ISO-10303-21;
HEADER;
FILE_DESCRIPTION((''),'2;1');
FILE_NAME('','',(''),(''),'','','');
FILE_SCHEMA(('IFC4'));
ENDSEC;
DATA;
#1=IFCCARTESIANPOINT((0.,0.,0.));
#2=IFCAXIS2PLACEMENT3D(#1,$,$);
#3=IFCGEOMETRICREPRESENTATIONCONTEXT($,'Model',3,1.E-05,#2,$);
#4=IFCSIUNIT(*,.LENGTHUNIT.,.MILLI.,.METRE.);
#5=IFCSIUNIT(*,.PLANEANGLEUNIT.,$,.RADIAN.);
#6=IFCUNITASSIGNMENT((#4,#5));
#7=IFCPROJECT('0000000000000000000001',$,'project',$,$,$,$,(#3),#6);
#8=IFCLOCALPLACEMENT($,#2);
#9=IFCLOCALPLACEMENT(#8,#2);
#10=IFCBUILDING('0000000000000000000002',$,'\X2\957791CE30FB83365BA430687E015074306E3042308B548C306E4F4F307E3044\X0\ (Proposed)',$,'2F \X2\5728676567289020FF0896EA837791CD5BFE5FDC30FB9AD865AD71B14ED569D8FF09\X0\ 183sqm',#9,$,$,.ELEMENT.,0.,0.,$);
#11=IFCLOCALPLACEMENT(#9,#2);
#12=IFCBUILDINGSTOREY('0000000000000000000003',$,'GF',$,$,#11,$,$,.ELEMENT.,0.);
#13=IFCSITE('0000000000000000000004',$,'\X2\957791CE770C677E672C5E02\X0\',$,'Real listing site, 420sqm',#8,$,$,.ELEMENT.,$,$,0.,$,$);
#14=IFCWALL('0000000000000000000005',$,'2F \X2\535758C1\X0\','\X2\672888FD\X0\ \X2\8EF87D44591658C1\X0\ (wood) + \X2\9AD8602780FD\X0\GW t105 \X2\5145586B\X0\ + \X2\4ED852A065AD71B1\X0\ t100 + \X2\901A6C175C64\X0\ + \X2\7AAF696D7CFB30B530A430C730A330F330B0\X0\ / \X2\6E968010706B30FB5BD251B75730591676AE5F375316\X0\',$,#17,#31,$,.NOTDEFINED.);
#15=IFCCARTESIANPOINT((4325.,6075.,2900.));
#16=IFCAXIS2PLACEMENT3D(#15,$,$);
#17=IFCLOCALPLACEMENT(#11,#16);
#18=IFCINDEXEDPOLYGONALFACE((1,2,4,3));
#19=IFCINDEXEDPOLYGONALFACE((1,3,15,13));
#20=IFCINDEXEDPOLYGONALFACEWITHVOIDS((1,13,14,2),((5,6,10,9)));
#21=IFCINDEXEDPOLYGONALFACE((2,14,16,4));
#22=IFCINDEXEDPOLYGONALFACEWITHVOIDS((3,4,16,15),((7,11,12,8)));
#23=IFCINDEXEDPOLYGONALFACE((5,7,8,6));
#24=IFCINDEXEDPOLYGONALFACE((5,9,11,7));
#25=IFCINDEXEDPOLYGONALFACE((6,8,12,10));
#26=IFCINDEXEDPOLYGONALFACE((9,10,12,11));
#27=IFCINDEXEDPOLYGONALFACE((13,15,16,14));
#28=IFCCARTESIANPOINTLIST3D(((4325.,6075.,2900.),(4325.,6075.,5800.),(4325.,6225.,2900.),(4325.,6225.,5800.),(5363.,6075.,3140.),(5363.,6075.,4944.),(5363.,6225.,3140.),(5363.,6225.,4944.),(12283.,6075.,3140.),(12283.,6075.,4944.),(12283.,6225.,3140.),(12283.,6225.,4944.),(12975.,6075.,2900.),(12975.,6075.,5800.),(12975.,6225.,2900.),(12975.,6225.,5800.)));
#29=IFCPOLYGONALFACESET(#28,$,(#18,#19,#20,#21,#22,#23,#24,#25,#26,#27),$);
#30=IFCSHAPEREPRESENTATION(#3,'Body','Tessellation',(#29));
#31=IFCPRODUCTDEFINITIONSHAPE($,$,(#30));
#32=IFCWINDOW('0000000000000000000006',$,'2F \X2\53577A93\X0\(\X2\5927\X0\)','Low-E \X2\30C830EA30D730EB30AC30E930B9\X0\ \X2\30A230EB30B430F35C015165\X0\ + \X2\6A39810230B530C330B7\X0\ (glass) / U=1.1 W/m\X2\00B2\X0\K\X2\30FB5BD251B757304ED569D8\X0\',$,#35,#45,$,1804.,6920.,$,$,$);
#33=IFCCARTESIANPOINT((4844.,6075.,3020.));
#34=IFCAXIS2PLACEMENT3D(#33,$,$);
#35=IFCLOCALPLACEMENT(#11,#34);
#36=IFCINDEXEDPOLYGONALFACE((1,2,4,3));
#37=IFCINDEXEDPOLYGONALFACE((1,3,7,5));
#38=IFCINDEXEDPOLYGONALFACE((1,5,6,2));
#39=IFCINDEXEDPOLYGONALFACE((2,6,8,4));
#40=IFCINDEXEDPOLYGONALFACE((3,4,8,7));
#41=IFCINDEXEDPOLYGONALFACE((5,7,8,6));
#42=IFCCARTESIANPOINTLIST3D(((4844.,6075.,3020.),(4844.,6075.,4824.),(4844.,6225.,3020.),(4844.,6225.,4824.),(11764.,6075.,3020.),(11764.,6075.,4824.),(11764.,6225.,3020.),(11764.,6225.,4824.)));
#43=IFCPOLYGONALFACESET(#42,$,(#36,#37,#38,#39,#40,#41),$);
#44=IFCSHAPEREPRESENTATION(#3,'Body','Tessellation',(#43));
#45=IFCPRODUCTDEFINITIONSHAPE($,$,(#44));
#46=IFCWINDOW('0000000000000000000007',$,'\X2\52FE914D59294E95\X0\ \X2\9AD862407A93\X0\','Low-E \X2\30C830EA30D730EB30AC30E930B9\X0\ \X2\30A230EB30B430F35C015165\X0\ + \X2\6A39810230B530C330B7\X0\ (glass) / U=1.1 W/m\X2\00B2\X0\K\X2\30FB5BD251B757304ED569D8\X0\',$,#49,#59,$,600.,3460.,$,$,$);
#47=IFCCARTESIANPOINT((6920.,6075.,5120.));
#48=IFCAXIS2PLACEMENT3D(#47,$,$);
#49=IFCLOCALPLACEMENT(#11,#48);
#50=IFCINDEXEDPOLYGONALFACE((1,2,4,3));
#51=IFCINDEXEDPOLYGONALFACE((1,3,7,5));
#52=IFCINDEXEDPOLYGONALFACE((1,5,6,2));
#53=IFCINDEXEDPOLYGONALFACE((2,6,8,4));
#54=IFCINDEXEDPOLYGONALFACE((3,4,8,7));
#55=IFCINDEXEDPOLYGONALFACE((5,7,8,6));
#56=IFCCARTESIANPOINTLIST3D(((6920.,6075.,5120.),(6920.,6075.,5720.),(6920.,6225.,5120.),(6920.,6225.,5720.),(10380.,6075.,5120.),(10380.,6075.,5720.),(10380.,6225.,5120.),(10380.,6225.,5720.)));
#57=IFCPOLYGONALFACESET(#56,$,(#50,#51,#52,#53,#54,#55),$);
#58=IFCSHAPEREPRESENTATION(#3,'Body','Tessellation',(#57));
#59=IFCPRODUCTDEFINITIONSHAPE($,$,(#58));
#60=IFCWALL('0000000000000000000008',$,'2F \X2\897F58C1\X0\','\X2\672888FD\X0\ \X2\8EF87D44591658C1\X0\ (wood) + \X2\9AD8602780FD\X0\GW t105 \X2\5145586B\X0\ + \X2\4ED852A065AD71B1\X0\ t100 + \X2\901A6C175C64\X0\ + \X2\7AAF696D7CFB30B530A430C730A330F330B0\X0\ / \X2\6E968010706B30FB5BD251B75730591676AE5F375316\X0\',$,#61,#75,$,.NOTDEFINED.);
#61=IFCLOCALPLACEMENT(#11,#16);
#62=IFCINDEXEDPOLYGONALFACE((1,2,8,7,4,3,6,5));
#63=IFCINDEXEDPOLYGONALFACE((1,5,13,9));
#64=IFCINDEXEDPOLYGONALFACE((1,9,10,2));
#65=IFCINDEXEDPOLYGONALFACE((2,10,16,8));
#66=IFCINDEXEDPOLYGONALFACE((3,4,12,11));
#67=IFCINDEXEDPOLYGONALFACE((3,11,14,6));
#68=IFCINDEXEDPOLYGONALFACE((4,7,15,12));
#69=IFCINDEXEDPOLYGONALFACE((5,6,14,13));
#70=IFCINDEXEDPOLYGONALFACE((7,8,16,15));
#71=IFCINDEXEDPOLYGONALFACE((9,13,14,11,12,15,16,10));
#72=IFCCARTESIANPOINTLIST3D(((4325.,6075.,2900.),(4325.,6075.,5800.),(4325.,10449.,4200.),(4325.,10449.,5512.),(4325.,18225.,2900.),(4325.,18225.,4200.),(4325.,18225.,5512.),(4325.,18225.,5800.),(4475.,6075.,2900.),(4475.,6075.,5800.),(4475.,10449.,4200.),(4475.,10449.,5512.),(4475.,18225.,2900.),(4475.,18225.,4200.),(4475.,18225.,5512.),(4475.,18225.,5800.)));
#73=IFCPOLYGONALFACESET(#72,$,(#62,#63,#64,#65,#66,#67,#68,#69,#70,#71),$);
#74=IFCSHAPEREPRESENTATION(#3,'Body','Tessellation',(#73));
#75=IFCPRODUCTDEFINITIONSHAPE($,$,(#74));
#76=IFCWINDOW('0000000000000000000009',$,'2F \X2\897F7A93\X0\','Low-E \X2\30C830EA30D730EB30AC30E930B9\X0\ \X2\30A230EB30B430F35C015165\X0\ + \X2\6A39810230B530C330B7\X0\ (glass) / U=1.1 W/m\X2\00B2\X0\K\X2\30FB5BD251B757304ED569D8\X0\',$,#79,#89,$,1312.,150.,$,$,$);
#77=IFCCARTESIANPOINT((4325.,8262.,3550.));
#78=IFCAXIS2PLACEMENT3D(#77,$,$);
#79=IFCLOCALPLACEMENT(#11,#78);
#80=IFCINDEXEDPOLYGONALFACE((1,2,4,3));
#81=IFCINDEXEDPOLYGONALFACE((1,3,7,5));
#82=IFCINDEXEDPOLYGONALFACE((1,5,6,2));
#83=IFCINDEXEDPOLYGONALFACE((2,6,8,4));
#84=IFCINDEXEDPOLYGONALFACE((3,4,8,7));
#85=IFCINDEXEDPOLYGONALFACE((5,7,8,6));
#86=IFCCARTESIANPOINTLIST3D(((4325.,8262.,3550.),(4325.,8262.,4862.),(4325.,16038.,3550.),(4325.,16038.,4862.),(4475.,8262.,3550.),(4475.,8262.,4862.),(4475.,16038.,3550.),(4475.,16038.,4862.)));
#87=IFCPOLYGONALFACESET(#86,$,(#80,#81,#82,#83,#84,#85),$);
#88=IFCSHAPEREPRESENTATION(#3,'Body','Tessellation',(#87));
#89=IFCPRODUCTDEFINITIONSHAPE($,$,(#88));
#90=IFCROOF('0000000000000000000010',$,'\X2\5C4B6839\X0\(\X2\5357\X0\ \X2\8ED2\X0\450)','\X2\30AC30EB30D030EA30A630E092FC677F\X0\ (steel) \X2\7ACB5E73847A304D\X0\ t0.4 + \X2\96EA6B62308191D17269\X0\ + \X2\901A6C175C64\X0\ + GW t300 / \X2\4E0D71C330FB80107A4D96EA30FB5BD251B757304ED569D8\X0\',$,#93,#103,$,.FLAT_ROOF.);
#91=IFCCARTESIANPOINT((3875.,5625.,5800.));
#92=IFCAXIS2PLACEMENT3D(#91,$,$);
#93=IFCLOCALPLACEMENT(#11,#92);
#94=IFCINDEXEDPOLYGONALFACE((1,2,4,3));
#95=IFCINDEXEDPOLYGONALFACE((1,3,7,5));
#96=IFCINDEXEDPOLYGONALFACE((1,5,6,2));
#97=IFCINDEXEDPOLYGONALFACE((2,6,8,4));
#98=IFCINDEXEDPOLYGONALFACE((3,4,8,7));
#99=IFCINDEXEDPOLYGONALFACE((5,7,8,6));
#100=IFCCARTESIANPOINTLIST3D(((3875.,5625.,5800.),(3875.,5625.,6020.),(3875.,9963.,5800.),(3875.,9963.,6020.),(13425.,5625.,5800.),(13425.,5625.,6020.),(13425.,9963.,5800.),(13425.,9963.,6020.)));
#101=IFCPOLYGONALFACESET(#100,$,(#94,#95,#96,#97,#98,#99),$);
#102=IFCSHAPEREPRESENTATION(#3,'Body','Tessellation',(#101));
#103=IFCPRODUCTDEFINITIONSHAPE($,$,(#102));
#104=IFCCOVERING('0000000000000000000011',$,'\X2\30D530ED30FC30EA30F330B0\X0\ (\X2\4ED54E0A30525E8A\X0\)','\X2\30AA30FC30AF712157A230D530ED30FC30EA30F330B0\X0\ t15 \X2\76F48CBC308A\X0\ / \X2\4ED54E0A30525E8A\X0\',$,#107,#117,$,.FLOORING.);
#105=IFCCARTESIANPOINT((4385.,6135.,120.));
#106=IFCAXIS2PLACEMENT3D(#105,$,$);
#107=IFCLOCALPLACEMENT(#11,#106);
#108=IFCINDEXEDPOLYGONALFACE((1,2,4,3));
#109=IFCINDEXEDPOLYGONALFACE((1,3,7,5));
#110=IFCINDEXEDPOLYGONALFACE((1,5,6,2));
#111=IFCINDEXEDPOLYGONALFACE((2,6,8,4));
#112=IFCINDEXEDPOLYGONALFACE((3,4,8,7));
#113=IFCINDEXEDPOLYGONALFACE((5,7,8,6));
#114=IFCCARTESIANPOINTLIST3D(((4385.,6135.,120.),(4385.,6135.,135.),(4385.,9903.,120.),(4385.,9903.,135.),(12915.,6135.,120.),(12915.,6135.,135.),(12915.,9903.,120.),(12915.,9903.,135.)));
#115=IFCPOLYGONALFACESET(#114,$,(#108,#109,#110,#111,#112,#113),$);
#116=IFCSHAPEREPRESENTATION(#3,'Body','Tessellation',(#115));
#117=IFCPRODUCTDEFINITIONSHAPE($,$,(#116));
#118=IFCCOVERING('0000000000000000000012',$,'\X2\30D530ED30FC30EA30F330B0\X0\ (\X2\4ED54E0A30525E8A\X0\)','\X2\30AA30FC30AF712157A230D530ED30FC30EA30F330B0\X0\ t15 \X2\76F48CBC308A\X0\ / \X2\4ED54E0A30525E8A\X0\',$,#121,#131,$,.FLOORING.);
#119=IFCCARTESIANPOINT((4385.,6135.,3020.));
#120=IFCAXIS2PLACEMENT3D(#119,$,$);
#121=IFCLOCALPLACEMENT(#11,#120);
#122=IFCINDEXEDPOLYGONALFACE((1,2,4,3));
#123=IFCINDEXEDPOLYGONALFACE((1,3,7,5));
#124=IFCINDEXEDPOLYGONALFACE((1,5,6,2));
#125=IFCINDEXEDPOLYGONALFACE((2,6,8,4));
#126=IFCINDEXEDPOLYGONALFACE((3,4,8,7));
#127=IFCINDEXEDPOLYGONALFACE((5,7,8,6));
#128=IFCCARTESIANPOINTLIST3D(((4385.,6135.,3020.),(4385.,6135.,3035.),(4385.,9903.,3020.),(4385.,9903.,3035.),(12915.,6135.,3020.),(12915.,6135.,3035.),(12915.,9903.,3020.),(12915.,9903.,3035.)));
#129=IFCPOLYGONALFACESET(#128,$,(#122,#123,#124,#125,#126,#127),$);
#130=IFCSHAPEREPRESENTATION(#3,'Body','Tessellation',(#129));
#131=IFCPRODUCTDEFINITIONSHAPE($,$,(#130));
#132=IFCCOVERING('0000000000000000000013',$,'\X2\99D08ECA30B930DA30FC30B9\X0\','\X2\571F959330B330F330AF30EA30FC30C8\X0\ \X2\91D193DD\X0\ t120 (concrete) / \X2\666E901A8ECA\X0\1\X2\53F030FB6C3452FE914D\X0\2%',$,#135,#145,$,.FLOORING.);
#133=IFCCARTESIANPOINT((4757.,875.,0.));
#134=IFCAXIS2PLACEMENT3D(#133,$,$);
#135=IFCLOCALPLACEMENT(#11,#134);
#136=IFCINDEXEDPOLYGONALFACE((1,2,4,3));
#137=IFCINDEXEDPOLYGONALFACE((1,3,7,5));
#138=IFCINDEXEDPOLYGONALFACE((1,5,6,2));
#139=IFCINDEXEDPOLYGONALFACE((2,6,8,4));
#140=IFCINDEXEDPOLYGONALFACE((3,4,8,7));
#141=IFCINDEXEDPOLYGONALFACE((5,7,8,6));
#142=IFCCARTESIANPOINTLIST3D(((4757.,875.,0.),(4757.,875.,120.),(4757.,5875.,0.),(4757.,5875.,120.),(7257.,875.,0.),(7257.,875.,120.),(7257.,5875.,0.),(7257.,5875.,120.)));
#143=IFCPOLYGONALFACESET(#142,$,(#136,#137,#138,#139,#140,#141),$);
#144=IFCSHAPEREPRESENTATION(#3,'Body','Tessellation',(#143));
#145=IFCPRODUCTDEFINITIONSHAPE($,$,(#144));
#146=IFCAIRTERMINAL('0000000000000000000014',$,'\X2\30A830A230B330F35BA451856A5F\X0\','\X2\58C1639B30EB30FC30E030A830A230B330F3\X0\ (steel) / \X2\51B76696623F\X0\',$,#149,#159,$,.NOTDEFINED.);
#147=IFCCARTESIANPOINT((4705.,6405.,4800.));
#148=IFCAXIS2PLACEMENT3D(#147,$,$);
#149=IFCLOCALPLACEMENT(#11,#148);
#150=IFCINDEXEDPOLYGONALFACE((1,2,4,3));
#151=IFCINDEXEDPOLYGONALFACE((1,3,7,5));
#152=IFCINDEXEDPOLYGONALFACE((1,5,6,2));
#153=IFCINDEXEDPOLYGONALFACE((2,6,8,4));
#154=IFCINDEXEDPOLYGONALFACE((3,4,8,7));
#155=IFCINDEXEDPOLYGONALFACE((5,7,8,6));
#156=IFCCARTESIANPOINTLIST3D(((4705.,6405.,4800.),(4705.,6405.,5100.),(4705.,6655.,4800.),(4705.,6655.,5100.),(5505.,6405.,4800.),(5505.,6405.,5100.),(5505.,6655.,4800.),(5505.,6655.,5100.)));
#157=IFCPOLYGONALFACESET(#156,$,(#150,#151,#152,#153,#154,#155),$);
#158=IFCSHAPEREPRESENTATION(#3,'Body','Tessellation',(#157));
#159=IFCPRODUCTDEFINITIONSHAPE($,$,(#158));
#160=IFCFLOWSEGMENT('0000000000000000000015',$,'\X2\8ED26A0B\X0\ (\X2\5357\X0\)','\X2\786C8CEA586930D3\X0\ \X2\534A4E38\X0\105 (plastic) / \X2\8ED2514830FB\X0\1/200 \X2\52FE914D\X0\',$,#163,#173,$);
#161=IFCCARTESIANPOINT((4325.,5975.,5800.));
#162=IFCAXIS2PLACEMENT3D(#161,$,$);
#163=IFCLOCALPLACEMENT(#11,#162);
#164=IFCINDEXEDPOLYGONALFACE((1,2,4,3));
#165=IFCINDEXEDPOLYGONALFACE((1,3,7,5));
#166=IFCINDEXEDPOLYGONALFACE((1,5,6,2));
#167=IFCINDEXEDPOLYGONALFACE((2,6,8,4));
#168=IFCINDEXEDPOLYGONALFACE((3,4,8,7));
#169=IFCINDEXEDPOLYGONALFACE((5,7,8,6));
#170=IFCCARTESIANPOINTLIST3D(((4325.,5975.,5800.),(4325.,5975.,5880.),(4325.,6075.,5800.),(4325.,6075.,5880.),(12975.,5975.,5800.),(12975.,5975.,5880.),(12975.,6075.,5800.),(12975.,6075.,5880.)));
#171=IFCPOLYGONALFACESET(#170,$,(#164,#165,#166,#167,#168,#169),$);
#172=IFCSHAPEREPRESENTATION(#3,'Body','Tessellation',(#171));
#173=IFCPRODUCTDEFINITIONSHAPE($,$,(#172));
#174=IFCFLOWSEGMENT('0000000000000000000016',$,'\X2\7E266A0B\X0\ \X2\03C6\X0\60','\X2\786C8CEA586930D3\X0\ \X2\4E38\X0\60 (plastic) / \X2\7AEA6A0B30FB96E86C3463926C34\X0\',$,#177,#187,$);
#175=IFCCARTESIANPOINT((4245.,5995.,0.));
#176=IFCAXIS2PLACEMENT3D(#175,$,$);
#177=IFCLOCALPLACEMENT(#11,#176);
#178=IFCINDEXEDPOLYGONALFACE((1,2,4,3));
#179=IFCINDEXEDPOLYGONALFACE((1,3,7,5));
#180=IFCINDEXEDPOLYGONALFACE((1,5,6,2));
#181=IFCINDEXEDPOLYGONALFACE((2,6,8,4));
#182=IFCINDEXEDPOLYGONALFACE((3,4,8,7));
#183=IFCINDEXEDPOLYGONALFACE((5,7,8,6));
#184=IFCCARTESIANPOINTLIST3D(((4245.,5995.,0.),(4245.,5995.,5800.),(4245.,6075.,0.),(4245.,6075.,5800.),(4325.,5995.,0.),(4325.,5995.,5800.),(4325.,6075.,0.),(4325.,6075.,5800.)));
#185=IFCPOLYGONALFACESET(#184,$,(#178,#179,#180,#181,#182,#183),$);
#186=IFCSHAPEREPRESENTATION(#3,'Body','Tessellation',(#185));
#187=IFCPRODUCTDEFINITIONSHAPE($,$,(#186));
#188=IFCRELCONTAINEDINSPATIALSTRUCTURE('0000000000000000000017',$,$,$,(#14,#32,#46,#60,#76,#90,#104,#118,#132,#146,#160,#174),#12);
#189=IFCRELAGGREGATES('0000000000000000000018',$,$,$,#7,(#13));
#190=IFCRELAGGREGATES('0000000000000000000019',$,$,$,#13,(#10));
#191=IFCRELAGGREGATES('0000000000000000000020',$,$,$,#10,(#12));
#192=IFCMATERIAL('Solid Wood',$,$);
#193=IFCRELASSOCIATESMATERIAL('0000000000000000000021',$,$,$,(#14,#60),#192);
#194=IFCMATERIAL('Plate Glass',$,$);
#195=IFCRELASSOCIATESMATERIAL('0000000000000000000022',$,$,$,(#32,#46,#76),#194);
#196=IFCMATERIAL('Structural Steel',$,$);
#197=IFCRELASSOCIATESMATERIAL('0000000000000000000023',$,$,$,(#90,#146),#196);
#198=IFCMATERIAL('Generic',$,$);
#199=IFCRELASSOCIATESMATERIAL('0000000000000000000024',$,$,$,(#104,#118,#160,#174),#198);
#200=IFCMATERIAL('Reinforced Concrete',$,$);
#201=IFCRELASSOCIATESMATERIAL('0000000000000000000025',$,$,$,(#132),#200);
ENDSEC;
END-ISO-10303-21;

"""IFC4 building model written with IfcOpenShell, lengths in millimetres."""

from ifc_helpers import new_model, si_unit, frame, frame_2d, origin, place, context, project, spatial, rectangle, extrude, material, element, fill, save


model = new_model("IFC4")

# Units and contexts
model_context = context("Model", 3, precision=1e-05, world=origin())
ifc_project = project(units=[si_unit("LENGTHUNIT", "METRE", prefix="MILLI"), si_unit("PLANEANGLEUNIT", "RADIAN")], contexts=[model_context])

# Site, building, storey
site_placement = place(None, origin())
site = spatial("IfcSite", under=ifc_project, at=site_placement, Name="長野県松本市", ObjectType="Real listing site, 420sqm", CompositionType="ELEMENT", RefElevation=0.0)
building_placement = place(site_placement, origin())
building = spatial("IfcBuilding", under=site, at=building_placement, Name="長野・茶室と縁側のある和の住まい (Proposed)", ObjectType="2F 在来木造（雪荷重対応・高断熱仕様） 183sqm", CompositionType="ELEMENT", ElevationOfRefHeight=0.0, ElevationOfTerrain=0.0)
storey_placement = place(building_placement, origin())
storey = spatial("IfcBuildingStorey", under=building, at=storey_placement, Name="GF", CompositionType="ELEMENT", Elevation=0.0)

# Shared definitions
ifc_material_1 = material(Name="Solid Wood")

# Shared definitions
ifc_material_2 = material(Name="Reinforced Concrete")

# Shared definitions
ifc_material_3 = material(Name="Plate Glass")

# Wall, openings, windows
wall_1_placement = place(storey_placement, frame((4325.0, 6075.0, 2900.0)))
wall_1 = element("IfcWall", 1, at=wall_1_placement, inside=storey, material=ifc_material_1, Name="2F 南壁", Description="木製 軸組外壁 (wood) + 高性能GW t105 充填 + 付加断熱 t100 + 通気層 + 窯業系サイディング / 準耐火・寒冷地外皮強化", PredefinedType="NOTDEFINED", context=model_context, shape_type="SweptSolid", body=[
    extrude(rectangle(XDim=8650.0, YDim=150.0, at=frame_2d((4325.0, 75.0))), frame((4325.0, 6075.0, 2900.0)), (0.0, 0.0, 1.0), 2900.0),
])
opening_1_placement = place(storey_placement, frame((4844.0, 6075.0, 3020.0)))
opening_1 = element("IfcOpeningElement", 2, at=opening_1_placement, cuts=wall_1, PredefinedType="NOTDEFINED", context=model_context, shape_type="SweptSolid", body=[
    extrude(rectangle(XDim=6920.0, YDim=150.0, at=frame_2d((3460.0, 75.0))), frame((4844.0, 6075.0, 3020.0)), (0.0, 0.0, 1.0), 1804.0),
])
opening_2_placement = place(storey_placement, frame((6920.0, 6075.0, 5120.0)))
opening_2 = element("IfcOpeningElement", 3, at=opening_2_placement, cuts=wall_1, PredefinedType="NOTDEFINED", context=model_context, shape_type="SweptSolid", body=[
    extrude(rectangle(XDim=3460.0, YDim=150.0, at=frame_2d((1730.0, 75.0))), frame((6920.0, 6075.0, 5120.0)), (0.0, 0.0, 1.0), 600.0),
])
window_1_placement = place(storey_placement, frame((4844.0, 6075.0, 3020.0)))
window_1 = element("IfcWindow", 4, at=window_1_placement, inside=storey, material=ifc_material_3, Name="2F 南窓(大)", Description="Low-E トリプルガラス アルゴン封入 + 樹脂サッシ (glass) / U=1.1 W/m²K・寒冷地仕様", OverallHeight=1804.0, OverallWidth=6920.0, context=model_context, shape_type="SweptSolid", body=[
    extrude(rectangle(XDim=6920.0, YDim=150.0, at=frame_2d((3460.0, 75.0))), frame((4844.0, 6075.0, 3020.0)), (0.0, 0.0, 1.0), 1804.0),
])
fill(opening_1, window_1)
window_2_placement = place(storey_placement, frame((6920.0, 6075.0, 5120.0)))
window_2 = element("IfcWindow", 5, at=window_2_placement, inside=storey, material=ifc_material_3, Name="勾配天井 高所窓", Description="Low-E トリプルガラス アルゴン封入 + 樹脂サッシ (glass) / U=1.1 W/m²K・寒冷地仕様", OverallHeight=600.0, OverallWidth=3460.0, context=model_context, shape_type="SweptSolid", body=[
    extrude(rectangle(XDim=3460.0, YDim=150.0, at=frame_2d((1730.0, 75.0))), frame((6920.0, 6075.0, 5120.0)), (0.0, 0.0, 1.0), 600.0),
])
fill(opening_2, window_2)

# Wall, opening, window
wall_2_placement = place(storey_placement, frame((4325.0, 6075.0, 2900.0)))
wall_2 = element("IfcWall", 6, at=wall_2_placement, inside=storey, material=ifc_material_1, Name="2F 西壁", Description="木製 軸組外壁 (wood) + 高性能GW t105 充填 + 付加断熱 t100 + 通気層 + 窯業系サイディング / 準耐火・寒冷地外皮強化", PredefinedType="NOTDEFINED", context=model_context, shape_type="SweptSolid", body=[
    extrude(rectangle(XDim=150.0, YDim=12150.0, at=frame_2d((75.0, 6075.0))), frame((4325.0, 6075.0, 2900.0)), (0.0, 0.0, 1.0), 2900.0),
])
opening_3_placement = place(storey_placement, frame((4325.0, 8262.0, 3550.0)))
opening_3 = element("IfcOpeningElement", 7, at=opening_3_placement, cuts=wall_2, PredefinedType="NOTDEFINED", context=model_context, shape_type="SweptSolid", body=[
    extrude(rectangle(XDim=150.0, YDim=7776.0, at=frame_2d((75.0, 3888.0))), frame((4325.0, 8262.0, 3550.0)), (0.0, 0.0, 1.0), 1312.0),
])
window_3_placement = place(storey_placement, frame((4325.0, 8262.0, 3550.0)))
window_3 = element("IfcWindow", 8, at=window_3_placement, inside=storey, material=ifc_material_3, Name="2F 西窓", Description="Low-E トリプルガラス アルゴン封入 + 樹脂サッシ (glass) / U=1.1 W/m²K・寒冷地仕様", OverallHeight=1312.0, OverallWidth=150.0, context=model_context, shape_type="SweptSolid", body=[
    extrude(rectangle(XDim=150.0, YDim=7776.0, at=frame_2d((75.0, 3888.0))), frame((4325.0, 8262.0, 3550.0)), (0.0, 0.0, 1.0), 1312.0),
])
fill(opening_3, window_3)

# Roof
ifc_material_4 = material(Name="Structural Steel")
for number, where, name in (
    (9, (3875.0, 5625.0, 5800.0), "屋根(南 軒450)"),
):
    element("IfcRoof", number, at=place(storey_placement, frame(where)), inside=storey, material=ifc_material_4, Name=name, Description="ガルバリウム鋼板 (steel) 立平葺き t0.4 + 雪止め金物 + 通気層 + GW t300 / 不燃・耐積雪・寒冷地仕様", PredefinedType="FLAT_ROOF", context=model_context, shape_type="SweptSolid", body=[
        extrude(rectangle(XDim=9550.0, YDim=4338.0, at=frame_2d((4775.0, 2169.0))), frame((3875.0, 5625.0, 5800.0)), (0.0, 0.0, 1.0), 220.0),
    ])

# Coverings
ifc_material_5 = material(Name="Generic")
covering_1_placement = place(storey_placement, frame((4385.0, 6135.0, 120.0)))
element("IfcCovering", 10, at=covering_1_placement, inside=storey, material=ifc_material_5, Name="フローリング (仕上げ床)", Description="オーク無垢フローリング t15 直貼り / 仕上げ床", PredefinedType="FLOORING", context=model_context, shape_type="SweptSolid", body=[
    extrude(rectangle(XDim=8530.0, YDim=3768.0, at=frame_2d((4265.0, 1884.0))), frame((4385.0, 6135.0, 120.0)), (0.0, 0.0, 1.0), 15.0),
])
covering_2_placement = place(storey_placement, frame((4385.0, 6135.0, 3020.0)))
element("IfcCovering", 11, at=covering_2_placement, inside=storey, material=ifc_material_5, Name="フローリング (仕上げ床)", Description="オーク無垢フローリング t15 直貼り / 仕上げ床", PredefinedType="FLOORING", context=model_context, shape_type="SweptSolid", body=[
    extrude(rectangle(XDim=8530.0, YDim=3768.0, at=frame_2d((4265.0, 1884.0))), frame((4385.0, 6135.0, 3020.0)), (0.0, 0.0, 1.0), 15.0),
])
covering_3_placement = place(storey_placement, frame((4757.0, 875.0, 0.0)))
element("IfcCovering", 12, at=covering_3_placement, inside=storey, material=ifc_material_2, Name="駐車スペース", Description="土間コンクリート 金鏝 t120 (concrete) / 普通車1台・水勾配2%", PredefinedType="FLOORING", context=model_context, shape_type="SweptSolid", body=[
    extrude(rectangle(XDim=2500.0, YDim=5000.0, at=frame_2d((1250.0, 2500.0))), frame((4757.0, 875.0, 0.0)), (0.0, 0.0, 1.0), 120.0),
])

# Air terminal
air_terminal_placement = place(storey_placement, frame((4705.0, 6405.0, 4800.0)))
element("IfcAirTerminal", 13, at=air_terminal_placement, inside=storey, material=ifc_material_4, Name="エアコン室内機", Description="壁掛ルームエアコン (steel) / 冷暖房", PredefinedType="NOTDEFINED", context=model_context, shape_type="SweptSolid", body=[
    extrude(rectangle(XDim=800.0, YDim=250.0, at=frame_2d((400.0, 125.0))), frame((4705.0, 6405.0, 4800.0)), (0.0, 0.0, 1.0), 300.0),
])

# Flow segments
flow_segment_1_placement = place(storey_placement, frame((4325.0, 5975.0, 5800.0)))
element("IfcFlowSegment", 14, at=flow_segment_1_placement, inside=storey, material=ifc_material_5, Name="軒樋 (南)", Description="硬質塩ビ 半丸105 (plastic) / 軒先・1/200 勾配", context=model_context, shape_type="SweptSolid", body=[
    extrude(rectangle(XDim=8650.0, YDim=100.0, at=frame_2d((4325.0, 50.0))), frame((4325.0, 5975.0, 5800.0)), (0.0, 0.0, 1.0), 80.0),
])
flow_segment_2_placement = place(storey_placement, frame((4245.0, 5995.0, 0.0)))
element("IfcFlowSegment", 15, at=flow_segment_2_placement, inside=storey, material=ifc_material_5, Name="縦樋 φ60", Description="硬質塩ビ 丸60 (plastic) / 竪樋・雨水排水", context=model_context, shape_type="SweptSolid", body=[
    extrude(rectangle(XDim=80.0, YDim=80.0, at=frame_2d((40.0, 40.0))), frame((4245.0, 5995.0, 0.0)), (0.0, 0.0, 1.0), 5800.0),
])

save(model, "model.ifc")
